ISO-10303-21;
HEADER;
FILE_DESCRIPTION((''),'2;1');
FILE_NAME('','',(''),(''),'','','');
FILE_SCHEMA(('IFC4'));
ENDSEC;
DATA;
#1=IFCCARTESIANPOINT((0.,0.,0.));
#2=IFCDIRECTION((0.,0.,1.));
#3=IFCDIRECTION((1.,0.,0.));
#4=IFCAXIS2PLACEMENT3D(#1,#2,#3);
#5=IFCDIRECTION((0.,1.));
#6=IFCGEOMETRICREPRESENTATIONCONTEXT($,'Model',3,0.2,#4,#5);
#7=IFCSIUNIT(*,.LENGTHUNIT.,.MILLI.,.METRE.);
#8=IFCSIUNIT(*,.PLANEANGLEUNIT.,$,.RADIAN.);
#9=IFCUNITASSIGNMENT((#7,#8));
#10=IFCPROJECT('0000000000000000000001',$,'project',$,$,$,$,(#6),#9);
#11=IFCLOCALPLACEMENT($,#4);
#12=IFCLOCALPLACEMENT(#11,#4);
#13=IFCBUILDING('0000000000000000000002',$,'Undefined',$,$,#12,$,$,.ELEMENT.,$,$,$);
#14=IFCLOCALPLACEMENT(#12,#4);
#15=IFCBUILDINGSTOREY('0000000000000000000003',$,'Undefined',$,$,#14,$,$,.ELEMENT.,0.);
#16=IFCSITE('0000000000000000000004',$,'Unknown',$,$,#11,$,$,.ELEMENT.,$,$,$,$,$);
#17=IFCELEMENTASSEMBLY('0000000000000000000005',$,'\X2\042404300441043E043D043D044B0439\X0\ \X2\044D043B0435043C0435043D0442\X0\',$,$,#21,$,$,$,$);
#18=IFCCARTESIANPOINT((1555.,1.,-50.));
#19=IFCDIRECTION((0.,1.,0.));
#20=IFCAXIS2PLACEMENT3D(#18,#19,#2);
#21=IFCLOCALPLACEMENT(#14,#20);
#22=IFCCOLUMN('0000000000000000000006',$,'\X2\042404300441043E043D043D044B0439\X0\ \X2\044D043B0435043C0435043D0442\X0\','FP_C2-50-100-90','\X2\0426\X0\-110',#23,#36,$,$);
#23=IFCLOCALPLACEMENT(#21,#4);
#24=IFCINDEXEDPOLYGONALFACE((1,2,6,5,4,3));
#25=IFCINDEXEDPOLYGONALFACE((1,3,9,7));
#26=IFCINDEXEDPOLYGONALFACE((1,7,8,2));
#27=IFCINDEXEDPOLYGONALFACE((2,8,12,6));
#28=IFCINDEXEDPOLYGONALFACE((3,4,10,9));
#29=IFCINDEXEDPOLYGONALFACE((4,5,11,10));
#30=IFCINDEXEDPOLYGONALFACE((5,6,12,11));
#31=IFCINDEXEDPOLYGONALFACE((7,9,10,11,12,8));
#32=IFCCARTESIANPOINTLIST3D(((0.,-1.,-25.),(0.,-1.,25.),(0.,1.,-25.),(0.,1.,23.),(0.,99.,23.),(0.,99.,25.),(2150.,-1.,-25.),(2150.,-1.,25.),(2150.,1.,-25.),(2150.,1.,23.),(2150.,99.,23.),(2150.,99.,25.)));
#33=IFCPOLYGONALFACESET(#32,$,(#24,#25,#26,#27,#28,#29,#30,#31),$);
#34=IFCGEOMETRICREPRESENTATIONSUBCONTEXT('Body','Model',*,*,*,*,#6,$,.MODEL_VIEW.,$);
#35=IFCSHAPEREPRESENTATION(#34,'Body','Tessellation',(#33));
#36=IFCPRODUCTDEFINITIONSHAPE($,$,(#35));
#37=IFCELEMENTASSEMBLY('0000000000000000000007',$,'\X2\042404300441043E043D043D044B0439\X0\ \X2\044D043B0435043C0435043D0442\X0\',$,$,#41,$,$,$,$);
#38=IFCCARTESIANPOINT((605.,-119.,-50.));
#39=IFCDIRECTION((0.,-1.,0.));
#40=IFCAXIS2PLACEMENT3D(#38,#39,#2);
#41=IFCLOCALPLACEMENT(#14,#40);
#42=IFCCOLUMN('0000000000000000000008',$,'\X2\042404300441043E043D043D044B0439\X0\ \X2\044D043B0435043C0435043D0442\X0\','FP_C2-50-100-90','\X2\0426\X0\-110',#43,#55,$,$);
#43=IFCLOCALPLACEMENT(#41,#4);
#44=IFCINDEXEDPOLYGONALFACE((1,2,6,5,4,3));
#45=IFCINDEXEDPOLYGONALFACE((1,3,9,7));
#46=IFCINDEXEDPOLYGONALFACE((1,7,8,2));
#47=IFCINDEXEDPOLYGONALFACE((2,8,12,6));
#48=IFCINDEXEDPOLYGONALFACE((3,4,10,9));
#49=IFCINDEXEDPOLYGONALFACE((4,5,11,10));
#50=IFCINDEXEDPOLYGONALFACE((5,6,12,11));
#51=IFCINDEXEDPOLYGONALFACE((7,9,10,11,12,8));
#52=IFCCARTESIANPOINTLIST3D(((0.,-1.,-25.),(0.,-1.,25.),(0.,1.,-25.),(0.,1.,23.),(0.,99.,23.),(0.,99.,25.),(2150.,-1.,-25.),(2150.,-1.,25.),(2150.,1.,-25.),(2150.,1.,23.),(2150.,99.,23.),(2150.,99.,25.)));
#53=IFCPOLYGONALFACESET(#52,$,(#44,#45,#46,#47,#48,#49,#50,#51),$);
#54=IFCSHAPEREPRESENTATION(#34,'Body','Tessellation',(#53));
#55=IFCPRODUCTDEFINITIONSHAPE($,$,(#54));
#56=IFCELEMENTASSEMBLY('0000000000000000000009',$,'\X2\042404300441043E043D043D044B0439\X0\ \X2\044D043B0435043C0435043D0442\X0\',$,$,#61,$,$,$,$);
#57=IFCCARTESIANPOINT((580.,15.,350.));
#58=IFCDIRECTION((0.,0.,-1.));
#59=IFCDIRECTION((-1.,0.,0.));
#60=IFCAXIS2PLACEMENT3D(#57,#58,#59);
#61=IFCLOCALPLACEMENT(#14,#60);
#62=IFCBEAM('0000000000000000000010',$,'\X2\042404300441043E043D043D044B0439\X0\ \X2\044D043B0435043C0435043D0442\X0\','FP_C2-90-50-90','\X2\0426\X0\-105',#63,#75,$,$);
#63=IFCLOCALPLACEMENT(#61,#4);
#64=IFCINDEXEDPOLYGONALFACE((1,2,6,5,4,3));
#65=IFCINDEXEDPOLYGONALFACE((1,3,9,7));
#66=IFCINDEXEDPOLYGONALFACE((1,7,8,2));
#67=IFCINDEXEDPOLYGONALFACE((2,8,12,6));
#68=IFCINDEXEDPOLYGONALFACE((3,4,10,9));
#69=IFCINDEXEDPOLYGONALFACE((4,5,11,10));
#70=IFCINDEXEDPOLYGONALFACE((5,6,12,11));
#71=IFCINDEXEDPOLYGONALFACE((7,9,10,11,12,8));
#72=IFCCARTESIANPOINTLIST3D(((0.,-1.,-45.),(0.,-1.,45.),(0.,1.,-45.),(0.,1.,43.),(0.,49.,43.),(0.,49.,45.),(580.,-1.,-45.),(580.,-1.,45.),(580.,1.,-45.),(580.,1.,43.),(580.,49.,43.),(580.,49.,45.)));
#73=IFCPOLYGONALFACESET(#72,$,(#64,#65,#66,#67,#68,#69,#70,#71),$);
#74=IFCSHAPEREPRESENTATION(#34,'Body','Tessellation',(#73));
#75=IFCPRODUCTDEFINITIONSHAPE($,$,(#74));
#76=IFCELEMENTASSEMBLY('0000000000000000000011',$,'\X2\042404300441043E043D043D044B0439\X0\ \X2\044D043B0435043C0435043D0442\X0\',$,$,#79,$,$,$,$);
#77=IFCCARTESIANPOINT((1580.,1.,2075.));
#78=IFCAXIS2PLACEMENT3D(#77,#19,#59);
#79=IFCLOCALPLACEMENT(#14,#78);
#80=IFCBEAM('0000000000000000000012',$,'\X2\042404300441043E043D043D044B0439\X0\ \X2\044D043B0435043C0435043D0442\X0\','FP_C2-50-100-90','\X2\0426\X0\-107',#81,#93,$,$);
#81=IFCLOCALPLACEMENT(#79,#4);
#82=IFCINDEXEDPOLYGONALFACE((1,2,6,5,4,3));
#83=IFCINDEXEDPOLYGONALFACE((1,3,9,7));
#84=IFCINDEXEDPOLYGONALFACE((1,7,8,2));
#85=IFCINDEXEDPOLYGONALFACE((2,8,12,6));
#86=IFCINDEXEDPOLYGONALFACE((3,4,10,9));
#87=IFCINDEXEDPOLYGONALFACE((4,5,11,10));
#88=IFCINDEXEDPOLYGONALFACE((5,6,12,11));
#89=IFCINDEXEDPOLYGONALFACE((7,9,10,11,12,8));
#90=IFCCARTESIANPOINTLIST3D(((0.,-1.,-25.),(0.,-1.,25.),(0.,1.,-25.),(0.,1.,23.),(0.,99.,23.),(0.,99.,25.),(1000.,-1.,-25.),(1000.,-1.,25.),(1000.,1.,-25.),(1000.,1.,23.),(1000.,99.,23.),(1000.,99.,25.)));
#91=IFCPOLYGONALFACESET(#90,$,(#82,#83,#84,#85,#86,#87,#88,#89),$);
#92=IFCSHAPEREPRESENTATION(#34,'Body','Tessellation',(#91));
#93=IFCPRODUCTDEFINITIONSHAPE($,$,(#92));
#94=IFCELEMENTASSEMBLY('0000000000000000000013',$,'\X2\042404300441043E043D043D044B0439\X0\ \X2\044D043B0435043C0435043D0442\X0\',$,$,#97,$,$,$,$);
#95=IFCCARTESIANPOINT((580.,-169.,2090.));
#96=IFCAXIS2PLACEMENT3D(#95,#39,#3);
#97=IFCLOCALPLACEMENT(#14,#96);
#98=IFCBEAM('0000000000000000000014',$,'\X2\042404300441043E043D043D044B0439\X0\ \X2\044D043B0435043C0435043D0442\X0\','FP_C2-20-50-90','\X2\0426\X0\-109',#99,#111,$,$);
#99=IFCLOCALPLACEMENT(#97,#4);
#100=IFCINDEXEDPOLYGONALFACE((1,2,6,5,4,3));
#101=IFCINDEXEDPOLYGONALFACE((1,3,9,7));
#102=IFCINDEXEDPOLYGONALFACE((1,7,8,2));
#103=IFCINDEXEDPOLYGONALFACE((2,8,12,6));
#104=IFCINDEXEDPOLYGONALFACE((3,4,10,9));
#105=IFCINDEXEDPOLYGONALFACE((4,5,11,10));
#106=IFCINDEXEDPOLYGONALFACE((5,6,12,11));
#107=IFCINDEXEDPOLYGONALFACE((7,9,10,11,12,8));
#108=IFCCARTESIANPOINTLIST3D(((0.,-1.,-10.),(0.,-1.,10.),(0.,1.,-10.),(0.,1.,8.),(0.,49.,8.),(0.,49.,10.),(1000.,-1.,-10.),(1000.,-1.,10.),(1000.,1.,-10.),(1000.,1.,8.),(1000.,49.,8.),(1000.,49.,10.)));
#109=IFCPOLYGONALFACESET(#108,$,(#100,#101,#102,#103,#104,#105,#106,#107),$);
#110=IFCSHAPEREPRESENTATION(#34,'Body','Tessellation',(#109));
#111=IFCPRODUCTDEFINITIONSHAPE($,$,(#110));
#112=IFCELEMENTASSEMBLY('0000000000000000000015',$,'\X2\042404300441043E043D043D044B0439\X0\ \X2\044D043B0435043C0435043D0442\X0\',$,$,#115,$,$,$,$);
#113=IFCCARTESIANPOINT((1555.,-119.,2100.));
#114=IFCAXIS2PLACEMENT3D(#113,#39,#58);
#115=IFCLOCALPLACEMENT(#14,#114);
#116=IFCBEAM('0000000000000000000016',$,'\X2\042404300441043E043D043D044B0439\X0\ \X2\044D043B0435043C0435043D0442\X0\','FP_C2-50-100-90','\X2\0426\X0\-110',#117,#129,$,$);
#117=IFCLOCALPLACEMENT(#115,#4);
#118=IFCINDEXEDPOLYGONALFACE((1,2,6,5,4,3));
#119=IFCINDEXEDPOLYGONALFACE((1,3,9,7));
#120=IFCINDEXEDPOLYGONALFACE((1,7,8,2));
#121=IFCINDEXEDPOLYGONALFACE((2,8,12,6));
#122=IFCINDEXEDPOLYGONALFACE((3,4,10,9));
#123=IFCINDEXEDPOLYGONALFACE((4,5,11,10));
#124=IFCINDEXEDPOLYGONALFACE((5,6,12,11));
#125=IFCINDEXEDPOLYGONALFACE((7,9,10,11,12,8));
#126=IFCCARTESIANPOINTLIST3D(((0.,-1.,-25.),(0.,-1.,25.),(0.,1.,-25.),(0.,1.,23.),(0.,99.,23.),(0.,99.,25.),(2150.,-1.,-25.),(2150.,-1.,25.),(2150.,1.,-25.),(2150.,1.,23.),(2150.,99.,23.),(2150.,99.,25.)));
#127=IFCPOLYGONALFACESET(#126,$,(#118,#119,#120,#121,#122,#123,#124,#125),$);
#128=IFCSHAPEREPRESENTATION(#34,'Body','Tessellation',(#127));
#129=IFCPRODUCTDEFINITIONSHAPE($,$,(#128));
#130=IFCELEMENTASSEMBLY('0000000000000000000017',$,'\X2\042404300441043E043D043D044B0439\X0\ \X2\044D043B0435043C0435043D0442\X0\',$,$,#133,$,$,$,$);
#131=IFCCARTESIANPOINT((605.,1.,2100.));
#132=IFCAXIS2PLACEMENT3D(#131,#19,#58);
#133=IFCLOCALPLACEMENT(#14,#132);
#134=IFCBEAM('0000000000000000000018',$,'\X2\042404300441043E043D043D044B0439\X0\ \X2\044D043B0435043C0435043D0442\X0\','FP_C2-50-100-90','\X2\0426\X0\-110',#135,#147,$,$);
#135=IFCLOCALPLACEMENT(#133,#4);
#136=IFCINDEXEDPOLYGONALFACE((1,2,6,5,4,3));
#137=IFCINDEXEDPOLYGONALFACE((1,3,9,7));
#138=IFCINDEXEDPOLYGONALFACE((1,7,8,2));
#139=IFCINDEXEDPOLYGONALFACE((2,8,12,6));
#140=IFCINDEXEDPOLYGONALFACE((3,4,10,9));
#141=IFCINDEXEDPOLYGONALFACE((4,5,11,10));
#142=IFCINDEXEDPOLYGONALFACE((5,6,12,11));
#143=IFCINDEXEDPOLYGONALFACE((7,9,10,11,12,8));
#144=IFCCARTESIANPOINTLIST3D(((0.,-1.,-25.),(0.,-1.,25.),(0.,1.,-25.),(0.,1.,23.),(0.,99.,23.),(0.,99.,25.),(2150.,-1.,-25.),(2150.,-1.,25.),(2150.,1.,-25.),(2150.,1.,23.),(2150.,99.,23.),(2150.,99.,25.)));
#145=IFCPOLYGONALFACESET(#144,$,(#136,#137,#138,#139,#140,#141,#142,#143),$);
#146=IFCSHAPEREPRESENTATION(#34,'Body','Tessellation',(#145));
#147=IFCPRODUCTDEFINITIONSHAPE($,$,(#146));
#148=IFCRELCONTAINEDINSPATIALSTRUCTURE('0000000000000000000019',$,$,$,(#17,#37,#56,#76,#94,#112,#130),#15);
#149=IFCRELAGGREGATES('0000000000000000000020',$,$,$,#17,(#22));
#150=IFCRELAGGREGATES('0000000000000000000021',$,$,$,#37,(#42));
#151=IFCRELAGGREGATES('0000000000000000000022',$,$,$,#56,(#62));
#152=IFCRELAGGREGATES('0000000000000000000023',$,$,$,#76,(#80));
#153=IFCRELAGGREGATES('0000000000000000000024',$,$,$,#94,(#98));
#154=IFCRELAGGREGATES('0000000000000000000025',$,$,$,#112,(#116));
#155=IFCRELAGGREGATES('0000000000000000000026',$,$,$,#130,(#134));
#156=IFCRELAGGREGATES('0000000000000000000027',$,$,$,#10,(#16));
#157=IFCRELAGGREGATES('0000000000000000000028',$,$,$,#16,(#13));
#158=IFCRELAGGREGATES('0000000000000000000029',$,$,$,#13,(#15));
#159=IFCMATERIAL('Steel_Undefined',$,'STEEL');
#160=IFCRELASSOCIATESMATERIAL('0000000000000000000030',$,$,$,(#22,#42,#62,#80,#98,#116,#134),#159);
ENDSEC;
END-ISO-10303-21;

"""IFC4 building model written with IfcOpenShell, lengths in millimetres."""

from ifc_helpers import new_model, si_unit, direction, frame, origin_with_axes, place, context, subcontext, project, spatial, line, indexed_curve, outline, extrude, material, element, aggregate, save


model = new_model("IFC4")

# Units and contexts
model_context = context("Model", 3, precision=0.2, world=origin_with_axes(), true_north=direction((0.0, 1.0)))
body_context = subcontext(model_context, "Body", "Model", "MODEL_VIEW")
ifc_project = project(units=[si_unit("LENGTHUNIT", "METRE", prefix="MILLI"), si_unit("PLANEANGLEUNIT", "RADIAN")], contexts=[model_context])

# Site, building, storey
site_placement = place(None, origin_with_axes())
site = spatial("IfcSite", under=ifc_project, at=site_placement, Name="Unknown", CompositionType="ELEMENT")
building_placement = place(site_placement, origin_with_axes())
building = spatial("IfcBuilding", under=site, at=building_placement, Name="Undefined", CompositionType="ELEMENT")
storey_placement = place(building_placement, origin_with_axes())
storey = spatial("IfcBuildingStorey", under=building, at=storey_placement, Name="Undefined", CompositionType="ELEMENT", Elevation=0.0)

# Element assemblies, columns
assembly_1_placement = place(storey_placement, frame((1555.0, 1.0, -50.0), z_axis=(0.0, 1.0, 0.0), x_axis=(0.0, 0.0, 1.0)))
assembly_1 = element("IfcElementAssembly", 1, at=assembly_1_placement, inside=storey, Name="Фасонный элемент")
ifc_material_1 = material(Name="Steel_Undefined", Category="STEEL")
column_1_placement = place(assembly_1_placement, origin_with_axes())
column_1 = element("IfcColumn", 2, at=column_1_placement, material=ifc_material_1, Name="Фасонный элемент", Description="FP_C2-50-100-90", ObjectType="Ц-110", context=body_context, shape_type="SolidModel", body=[
    extrude(outline(indexed_curve([(-25.0, -1.0), (25.0, -1.0), (25.0, 99.0), (23.0, 99.0), (23.0, 1.0), (-25.0, 1.0)], segments=[line(1, 2, 3, 4, 5, 6, 1)])), frame((0.0, 0.0, 0.0), z_axis=(-1.0, 0.0, 0.0), x_axis=(0.0, 0.0, 1.0)), (0.0, 0.0, -1.0), 2150.0),
])
aggregate(assembly_1, [column_1])
assembly_2_placement = place(storey_placement, frame((605.0, -119.0, -50.0), z_axis=(0.0, -1.0, 0.0), x_axis=(0.0, 0.0, 1.0)))
assembly_2 = element("IfcElementAssembly", 3, at=assembly_2_placement, inside=storey, Name="Фасонный элемент")
column_2_placement = place(assembly_2_placement, origin_with_axes())
column_2 = element("IfcColumn", 4, at=column_2_placement, material=ifc_material_1, Name="Фасонный элемент", Description="FP_C2-50-100-90", ObjectType="Ц-110", context=body_context, shape_type="SolidModel", body=[
    extrude(outline(indexed_curve([(-25.0, -1.0), (25.0, -1.0), (25.0, 99.0), (23.0, 99.0), (23.0, 1.0), (-25.0, 1.0)], segments=[line(1, 2, 3, 4, 5, 6, 1)])), frame((0.0, 0.0, 0.0), z_axis=(-1.0, 0.0, 0.0), x_axis=(0.0, 0.0, 1.0)), (0.0, 0.0, -1.0), 2150.0),
])
aggregate(assembly_2, [column_2])

# Element assemblies, beams
assembly_3_placement = place(storey_placement, frame((580.0, 15.0, 350.0), z_axis=(0.0, 0.0, -1.0), x_axis=(-1.0, 0.0, 0.0)))
assembly_3 = element("IfcElementAssembly", 5, at=assembly_3_placement, inside=storey, Name="Фасонный элемент")
beam_1_placement = place(assembly_3_placement, origin_with_axes())
beam_1 = element("IfcBeam", 6, at=beam_1_placement, material=ifc_material_1, Name="Фасонный элемент", Description="FP_C2-90-50-90", ObjectType="Ц-105", context=body_context, shape_type="SolidModel", body=[
    extrude(outline(indexed_curve([(-45.0, -1.0), (45.0, -1.0), (45.0, 49.0), (43.0, 49.0), (43.0, 1.0), (-45.0, 1.0)], segments=[line(1, 2, 3, 4, 5, 6, 1)])), frame((0.0, 0.0, 0.0), z_axis=(-1.0, 0.0, 0.0), x_axis=(0.0, 0.0, 1.0)), (0.0, 0.0, -1.0), 580.0),
])
aggregate(assembly_3, [beam_1])
assembly_4_placement = place(storey_placement, frame((1580.0, 1.0, 2075.0), z_axis=(0.0, 1.0, 0.0), x_axis=(-1.0, 0.0, 0.0)))
assembly_4 = element("IfcElementAssembly", 7, at=assembly_4_placement, inside=storey, Name="Фасонный элемент")
beam_2_placement = place(assembly_4_placement, origin_with_axes())
beam_2 = element("IfcBeam", 8, at=beam_2_placement, material=ifc_material_1, Name="Фасонный элемент", Description="FP_C2-50-100-90", ObjectType="Ц-107", context=body_context, shape_type="SolidModel", body=[
    extrude(outline(indexed_curve([(-25.0, -1.0), (25.0, -1.0), (25.0, 99.0), (23.0, 99.0), (23.0, 1.0), (-25.0, 1.0)], segments=[line(1, 2, 3, 4, 5, 6, 1)])), frame((0.0, 0.0, 0.0), z_axis=(-1.0, 0.0, 0.0), x_axis=(0.0, 0.0, 1.0)), (0.0, 0.0, -1.0), 1000.0),
])
aggregate(assembly_4, [beam_2])
assembly_5_placement = place(storey_placement, frame((580.0, -169.0, 2090.0), z_axis=(0.0, -1.0, 0.0), x_axis=(1.0, 0.0, 0.0)))
assembly_5 = element("IfcElementAssembly", 9, at=assembly_5_placement, inside=storey, Name="Фасонный элемент")
beam_3_placement = place(assembly_5_placement, origin_with_axes())
beam_3 = element("IfcBeam", 10, at=beam_3_placement, material=ifc_material_1, Name="Фасонный элемент", Description="FP_C2-20-50-90", ObjectType="Ц-109", context=body_context, shape_type="SolidModel", body=[
    extrude(outline(indexed_curve([(-10.0, -1.0), (10.0, -1.0), (10.0, 49.0), (8.0, 49.0), (8.0, 1.0), (-10.0, 1.0)], segments=[line(1, 2, 3, 4, 5, 6, 1)])), frame((0.0, 0.0, 0.0), z_axis=(-1.0, 0.0, 0.0), x_axis=(0.0, 0.0, 1.0)), (0.0, 0.0, -1.0), 1000.0),
])
aggregate(assembly_5, [beam_3])
assembly_6_placement = place(storey_placement, frame((1555.0, -119.0, 2100.0), z_axis=(0.0, -1.0, 0.0), x_axis=(0.0, 0.0, -1.0)))
assembly_6 = element("IfcElementAssembly", 11, at=assembly_6_placement, inside=storey, Name="Фасонный элемент")
beam_4_placement = place(assembly_6_placement, origin_with_axes())
beam_4 = element("IfcBeam", 12, at=beam_4_placement, material=ifc_material_1, Name="Фасонный элемент", Description="FP_C2-50-100-90", ObjectType="Ц-110", context=body_context, shape_type="SolidModel", body=[
    extrude(outline(indexed_curve([(-25.0, -1.0), (25.0, -1.0), (25.0, 99.0), (23.0, 99.0), (23.0, 1.0), (-25.0, 1.0)], segments=[line(1, 2, 3, 4, 5, 6, 1)])), frame((0.0, 0.0, 0.0), z_axis=(-1.0, 0.0, 0.0), x_axis=(0.0, 0.0, 1.0)), (0.0, 0.0, -1.0), 2150.0),
])
aggregate(assembly_6, [beam_4])
assembly_7_placement = place(storey_placement, frame((605.0, 1.0, 2100.0), z_axis=(0.0, 1.0, 0.0), x_axis=(0.0, 0.0, -1.0)))
assembly_7 = element("IfcElementAssembly", 13, at=assembly_7_placement, inside=storey, Name="Фасонный элемент")
beam_5_placement = place(assembly_7_placement, origin_with_axes())
beam_5 = element("IfcBeam", 14, at=beam_5_placement, material=ifc_material_1, Name="Фасонный элемент", Description="FP_C2-50-100-90", ObjectType="Ц-110", context=body_context, shape_type="SolidModel", body=[
    extrude(outline(indexed_curve([(-25.0, -1.0), (25.0, -1.0), (25.0, 99.0), (23.0, 99.0), (23.0, 1.0), (-25.0, 1.0)], segments=[line(1, 2, 3, 4, 5, 6, 1)])), frame((0.0, 0.0, 0.0), z_axis=(-1.0, 0.0, 0.0), x_axis=(0.0, 0.0, 1.0)), (0.0, 0.0, -1.0), 2150.0),
])
aggregate(assembly_7, [beam_5])

save(model, "model.ifc")
